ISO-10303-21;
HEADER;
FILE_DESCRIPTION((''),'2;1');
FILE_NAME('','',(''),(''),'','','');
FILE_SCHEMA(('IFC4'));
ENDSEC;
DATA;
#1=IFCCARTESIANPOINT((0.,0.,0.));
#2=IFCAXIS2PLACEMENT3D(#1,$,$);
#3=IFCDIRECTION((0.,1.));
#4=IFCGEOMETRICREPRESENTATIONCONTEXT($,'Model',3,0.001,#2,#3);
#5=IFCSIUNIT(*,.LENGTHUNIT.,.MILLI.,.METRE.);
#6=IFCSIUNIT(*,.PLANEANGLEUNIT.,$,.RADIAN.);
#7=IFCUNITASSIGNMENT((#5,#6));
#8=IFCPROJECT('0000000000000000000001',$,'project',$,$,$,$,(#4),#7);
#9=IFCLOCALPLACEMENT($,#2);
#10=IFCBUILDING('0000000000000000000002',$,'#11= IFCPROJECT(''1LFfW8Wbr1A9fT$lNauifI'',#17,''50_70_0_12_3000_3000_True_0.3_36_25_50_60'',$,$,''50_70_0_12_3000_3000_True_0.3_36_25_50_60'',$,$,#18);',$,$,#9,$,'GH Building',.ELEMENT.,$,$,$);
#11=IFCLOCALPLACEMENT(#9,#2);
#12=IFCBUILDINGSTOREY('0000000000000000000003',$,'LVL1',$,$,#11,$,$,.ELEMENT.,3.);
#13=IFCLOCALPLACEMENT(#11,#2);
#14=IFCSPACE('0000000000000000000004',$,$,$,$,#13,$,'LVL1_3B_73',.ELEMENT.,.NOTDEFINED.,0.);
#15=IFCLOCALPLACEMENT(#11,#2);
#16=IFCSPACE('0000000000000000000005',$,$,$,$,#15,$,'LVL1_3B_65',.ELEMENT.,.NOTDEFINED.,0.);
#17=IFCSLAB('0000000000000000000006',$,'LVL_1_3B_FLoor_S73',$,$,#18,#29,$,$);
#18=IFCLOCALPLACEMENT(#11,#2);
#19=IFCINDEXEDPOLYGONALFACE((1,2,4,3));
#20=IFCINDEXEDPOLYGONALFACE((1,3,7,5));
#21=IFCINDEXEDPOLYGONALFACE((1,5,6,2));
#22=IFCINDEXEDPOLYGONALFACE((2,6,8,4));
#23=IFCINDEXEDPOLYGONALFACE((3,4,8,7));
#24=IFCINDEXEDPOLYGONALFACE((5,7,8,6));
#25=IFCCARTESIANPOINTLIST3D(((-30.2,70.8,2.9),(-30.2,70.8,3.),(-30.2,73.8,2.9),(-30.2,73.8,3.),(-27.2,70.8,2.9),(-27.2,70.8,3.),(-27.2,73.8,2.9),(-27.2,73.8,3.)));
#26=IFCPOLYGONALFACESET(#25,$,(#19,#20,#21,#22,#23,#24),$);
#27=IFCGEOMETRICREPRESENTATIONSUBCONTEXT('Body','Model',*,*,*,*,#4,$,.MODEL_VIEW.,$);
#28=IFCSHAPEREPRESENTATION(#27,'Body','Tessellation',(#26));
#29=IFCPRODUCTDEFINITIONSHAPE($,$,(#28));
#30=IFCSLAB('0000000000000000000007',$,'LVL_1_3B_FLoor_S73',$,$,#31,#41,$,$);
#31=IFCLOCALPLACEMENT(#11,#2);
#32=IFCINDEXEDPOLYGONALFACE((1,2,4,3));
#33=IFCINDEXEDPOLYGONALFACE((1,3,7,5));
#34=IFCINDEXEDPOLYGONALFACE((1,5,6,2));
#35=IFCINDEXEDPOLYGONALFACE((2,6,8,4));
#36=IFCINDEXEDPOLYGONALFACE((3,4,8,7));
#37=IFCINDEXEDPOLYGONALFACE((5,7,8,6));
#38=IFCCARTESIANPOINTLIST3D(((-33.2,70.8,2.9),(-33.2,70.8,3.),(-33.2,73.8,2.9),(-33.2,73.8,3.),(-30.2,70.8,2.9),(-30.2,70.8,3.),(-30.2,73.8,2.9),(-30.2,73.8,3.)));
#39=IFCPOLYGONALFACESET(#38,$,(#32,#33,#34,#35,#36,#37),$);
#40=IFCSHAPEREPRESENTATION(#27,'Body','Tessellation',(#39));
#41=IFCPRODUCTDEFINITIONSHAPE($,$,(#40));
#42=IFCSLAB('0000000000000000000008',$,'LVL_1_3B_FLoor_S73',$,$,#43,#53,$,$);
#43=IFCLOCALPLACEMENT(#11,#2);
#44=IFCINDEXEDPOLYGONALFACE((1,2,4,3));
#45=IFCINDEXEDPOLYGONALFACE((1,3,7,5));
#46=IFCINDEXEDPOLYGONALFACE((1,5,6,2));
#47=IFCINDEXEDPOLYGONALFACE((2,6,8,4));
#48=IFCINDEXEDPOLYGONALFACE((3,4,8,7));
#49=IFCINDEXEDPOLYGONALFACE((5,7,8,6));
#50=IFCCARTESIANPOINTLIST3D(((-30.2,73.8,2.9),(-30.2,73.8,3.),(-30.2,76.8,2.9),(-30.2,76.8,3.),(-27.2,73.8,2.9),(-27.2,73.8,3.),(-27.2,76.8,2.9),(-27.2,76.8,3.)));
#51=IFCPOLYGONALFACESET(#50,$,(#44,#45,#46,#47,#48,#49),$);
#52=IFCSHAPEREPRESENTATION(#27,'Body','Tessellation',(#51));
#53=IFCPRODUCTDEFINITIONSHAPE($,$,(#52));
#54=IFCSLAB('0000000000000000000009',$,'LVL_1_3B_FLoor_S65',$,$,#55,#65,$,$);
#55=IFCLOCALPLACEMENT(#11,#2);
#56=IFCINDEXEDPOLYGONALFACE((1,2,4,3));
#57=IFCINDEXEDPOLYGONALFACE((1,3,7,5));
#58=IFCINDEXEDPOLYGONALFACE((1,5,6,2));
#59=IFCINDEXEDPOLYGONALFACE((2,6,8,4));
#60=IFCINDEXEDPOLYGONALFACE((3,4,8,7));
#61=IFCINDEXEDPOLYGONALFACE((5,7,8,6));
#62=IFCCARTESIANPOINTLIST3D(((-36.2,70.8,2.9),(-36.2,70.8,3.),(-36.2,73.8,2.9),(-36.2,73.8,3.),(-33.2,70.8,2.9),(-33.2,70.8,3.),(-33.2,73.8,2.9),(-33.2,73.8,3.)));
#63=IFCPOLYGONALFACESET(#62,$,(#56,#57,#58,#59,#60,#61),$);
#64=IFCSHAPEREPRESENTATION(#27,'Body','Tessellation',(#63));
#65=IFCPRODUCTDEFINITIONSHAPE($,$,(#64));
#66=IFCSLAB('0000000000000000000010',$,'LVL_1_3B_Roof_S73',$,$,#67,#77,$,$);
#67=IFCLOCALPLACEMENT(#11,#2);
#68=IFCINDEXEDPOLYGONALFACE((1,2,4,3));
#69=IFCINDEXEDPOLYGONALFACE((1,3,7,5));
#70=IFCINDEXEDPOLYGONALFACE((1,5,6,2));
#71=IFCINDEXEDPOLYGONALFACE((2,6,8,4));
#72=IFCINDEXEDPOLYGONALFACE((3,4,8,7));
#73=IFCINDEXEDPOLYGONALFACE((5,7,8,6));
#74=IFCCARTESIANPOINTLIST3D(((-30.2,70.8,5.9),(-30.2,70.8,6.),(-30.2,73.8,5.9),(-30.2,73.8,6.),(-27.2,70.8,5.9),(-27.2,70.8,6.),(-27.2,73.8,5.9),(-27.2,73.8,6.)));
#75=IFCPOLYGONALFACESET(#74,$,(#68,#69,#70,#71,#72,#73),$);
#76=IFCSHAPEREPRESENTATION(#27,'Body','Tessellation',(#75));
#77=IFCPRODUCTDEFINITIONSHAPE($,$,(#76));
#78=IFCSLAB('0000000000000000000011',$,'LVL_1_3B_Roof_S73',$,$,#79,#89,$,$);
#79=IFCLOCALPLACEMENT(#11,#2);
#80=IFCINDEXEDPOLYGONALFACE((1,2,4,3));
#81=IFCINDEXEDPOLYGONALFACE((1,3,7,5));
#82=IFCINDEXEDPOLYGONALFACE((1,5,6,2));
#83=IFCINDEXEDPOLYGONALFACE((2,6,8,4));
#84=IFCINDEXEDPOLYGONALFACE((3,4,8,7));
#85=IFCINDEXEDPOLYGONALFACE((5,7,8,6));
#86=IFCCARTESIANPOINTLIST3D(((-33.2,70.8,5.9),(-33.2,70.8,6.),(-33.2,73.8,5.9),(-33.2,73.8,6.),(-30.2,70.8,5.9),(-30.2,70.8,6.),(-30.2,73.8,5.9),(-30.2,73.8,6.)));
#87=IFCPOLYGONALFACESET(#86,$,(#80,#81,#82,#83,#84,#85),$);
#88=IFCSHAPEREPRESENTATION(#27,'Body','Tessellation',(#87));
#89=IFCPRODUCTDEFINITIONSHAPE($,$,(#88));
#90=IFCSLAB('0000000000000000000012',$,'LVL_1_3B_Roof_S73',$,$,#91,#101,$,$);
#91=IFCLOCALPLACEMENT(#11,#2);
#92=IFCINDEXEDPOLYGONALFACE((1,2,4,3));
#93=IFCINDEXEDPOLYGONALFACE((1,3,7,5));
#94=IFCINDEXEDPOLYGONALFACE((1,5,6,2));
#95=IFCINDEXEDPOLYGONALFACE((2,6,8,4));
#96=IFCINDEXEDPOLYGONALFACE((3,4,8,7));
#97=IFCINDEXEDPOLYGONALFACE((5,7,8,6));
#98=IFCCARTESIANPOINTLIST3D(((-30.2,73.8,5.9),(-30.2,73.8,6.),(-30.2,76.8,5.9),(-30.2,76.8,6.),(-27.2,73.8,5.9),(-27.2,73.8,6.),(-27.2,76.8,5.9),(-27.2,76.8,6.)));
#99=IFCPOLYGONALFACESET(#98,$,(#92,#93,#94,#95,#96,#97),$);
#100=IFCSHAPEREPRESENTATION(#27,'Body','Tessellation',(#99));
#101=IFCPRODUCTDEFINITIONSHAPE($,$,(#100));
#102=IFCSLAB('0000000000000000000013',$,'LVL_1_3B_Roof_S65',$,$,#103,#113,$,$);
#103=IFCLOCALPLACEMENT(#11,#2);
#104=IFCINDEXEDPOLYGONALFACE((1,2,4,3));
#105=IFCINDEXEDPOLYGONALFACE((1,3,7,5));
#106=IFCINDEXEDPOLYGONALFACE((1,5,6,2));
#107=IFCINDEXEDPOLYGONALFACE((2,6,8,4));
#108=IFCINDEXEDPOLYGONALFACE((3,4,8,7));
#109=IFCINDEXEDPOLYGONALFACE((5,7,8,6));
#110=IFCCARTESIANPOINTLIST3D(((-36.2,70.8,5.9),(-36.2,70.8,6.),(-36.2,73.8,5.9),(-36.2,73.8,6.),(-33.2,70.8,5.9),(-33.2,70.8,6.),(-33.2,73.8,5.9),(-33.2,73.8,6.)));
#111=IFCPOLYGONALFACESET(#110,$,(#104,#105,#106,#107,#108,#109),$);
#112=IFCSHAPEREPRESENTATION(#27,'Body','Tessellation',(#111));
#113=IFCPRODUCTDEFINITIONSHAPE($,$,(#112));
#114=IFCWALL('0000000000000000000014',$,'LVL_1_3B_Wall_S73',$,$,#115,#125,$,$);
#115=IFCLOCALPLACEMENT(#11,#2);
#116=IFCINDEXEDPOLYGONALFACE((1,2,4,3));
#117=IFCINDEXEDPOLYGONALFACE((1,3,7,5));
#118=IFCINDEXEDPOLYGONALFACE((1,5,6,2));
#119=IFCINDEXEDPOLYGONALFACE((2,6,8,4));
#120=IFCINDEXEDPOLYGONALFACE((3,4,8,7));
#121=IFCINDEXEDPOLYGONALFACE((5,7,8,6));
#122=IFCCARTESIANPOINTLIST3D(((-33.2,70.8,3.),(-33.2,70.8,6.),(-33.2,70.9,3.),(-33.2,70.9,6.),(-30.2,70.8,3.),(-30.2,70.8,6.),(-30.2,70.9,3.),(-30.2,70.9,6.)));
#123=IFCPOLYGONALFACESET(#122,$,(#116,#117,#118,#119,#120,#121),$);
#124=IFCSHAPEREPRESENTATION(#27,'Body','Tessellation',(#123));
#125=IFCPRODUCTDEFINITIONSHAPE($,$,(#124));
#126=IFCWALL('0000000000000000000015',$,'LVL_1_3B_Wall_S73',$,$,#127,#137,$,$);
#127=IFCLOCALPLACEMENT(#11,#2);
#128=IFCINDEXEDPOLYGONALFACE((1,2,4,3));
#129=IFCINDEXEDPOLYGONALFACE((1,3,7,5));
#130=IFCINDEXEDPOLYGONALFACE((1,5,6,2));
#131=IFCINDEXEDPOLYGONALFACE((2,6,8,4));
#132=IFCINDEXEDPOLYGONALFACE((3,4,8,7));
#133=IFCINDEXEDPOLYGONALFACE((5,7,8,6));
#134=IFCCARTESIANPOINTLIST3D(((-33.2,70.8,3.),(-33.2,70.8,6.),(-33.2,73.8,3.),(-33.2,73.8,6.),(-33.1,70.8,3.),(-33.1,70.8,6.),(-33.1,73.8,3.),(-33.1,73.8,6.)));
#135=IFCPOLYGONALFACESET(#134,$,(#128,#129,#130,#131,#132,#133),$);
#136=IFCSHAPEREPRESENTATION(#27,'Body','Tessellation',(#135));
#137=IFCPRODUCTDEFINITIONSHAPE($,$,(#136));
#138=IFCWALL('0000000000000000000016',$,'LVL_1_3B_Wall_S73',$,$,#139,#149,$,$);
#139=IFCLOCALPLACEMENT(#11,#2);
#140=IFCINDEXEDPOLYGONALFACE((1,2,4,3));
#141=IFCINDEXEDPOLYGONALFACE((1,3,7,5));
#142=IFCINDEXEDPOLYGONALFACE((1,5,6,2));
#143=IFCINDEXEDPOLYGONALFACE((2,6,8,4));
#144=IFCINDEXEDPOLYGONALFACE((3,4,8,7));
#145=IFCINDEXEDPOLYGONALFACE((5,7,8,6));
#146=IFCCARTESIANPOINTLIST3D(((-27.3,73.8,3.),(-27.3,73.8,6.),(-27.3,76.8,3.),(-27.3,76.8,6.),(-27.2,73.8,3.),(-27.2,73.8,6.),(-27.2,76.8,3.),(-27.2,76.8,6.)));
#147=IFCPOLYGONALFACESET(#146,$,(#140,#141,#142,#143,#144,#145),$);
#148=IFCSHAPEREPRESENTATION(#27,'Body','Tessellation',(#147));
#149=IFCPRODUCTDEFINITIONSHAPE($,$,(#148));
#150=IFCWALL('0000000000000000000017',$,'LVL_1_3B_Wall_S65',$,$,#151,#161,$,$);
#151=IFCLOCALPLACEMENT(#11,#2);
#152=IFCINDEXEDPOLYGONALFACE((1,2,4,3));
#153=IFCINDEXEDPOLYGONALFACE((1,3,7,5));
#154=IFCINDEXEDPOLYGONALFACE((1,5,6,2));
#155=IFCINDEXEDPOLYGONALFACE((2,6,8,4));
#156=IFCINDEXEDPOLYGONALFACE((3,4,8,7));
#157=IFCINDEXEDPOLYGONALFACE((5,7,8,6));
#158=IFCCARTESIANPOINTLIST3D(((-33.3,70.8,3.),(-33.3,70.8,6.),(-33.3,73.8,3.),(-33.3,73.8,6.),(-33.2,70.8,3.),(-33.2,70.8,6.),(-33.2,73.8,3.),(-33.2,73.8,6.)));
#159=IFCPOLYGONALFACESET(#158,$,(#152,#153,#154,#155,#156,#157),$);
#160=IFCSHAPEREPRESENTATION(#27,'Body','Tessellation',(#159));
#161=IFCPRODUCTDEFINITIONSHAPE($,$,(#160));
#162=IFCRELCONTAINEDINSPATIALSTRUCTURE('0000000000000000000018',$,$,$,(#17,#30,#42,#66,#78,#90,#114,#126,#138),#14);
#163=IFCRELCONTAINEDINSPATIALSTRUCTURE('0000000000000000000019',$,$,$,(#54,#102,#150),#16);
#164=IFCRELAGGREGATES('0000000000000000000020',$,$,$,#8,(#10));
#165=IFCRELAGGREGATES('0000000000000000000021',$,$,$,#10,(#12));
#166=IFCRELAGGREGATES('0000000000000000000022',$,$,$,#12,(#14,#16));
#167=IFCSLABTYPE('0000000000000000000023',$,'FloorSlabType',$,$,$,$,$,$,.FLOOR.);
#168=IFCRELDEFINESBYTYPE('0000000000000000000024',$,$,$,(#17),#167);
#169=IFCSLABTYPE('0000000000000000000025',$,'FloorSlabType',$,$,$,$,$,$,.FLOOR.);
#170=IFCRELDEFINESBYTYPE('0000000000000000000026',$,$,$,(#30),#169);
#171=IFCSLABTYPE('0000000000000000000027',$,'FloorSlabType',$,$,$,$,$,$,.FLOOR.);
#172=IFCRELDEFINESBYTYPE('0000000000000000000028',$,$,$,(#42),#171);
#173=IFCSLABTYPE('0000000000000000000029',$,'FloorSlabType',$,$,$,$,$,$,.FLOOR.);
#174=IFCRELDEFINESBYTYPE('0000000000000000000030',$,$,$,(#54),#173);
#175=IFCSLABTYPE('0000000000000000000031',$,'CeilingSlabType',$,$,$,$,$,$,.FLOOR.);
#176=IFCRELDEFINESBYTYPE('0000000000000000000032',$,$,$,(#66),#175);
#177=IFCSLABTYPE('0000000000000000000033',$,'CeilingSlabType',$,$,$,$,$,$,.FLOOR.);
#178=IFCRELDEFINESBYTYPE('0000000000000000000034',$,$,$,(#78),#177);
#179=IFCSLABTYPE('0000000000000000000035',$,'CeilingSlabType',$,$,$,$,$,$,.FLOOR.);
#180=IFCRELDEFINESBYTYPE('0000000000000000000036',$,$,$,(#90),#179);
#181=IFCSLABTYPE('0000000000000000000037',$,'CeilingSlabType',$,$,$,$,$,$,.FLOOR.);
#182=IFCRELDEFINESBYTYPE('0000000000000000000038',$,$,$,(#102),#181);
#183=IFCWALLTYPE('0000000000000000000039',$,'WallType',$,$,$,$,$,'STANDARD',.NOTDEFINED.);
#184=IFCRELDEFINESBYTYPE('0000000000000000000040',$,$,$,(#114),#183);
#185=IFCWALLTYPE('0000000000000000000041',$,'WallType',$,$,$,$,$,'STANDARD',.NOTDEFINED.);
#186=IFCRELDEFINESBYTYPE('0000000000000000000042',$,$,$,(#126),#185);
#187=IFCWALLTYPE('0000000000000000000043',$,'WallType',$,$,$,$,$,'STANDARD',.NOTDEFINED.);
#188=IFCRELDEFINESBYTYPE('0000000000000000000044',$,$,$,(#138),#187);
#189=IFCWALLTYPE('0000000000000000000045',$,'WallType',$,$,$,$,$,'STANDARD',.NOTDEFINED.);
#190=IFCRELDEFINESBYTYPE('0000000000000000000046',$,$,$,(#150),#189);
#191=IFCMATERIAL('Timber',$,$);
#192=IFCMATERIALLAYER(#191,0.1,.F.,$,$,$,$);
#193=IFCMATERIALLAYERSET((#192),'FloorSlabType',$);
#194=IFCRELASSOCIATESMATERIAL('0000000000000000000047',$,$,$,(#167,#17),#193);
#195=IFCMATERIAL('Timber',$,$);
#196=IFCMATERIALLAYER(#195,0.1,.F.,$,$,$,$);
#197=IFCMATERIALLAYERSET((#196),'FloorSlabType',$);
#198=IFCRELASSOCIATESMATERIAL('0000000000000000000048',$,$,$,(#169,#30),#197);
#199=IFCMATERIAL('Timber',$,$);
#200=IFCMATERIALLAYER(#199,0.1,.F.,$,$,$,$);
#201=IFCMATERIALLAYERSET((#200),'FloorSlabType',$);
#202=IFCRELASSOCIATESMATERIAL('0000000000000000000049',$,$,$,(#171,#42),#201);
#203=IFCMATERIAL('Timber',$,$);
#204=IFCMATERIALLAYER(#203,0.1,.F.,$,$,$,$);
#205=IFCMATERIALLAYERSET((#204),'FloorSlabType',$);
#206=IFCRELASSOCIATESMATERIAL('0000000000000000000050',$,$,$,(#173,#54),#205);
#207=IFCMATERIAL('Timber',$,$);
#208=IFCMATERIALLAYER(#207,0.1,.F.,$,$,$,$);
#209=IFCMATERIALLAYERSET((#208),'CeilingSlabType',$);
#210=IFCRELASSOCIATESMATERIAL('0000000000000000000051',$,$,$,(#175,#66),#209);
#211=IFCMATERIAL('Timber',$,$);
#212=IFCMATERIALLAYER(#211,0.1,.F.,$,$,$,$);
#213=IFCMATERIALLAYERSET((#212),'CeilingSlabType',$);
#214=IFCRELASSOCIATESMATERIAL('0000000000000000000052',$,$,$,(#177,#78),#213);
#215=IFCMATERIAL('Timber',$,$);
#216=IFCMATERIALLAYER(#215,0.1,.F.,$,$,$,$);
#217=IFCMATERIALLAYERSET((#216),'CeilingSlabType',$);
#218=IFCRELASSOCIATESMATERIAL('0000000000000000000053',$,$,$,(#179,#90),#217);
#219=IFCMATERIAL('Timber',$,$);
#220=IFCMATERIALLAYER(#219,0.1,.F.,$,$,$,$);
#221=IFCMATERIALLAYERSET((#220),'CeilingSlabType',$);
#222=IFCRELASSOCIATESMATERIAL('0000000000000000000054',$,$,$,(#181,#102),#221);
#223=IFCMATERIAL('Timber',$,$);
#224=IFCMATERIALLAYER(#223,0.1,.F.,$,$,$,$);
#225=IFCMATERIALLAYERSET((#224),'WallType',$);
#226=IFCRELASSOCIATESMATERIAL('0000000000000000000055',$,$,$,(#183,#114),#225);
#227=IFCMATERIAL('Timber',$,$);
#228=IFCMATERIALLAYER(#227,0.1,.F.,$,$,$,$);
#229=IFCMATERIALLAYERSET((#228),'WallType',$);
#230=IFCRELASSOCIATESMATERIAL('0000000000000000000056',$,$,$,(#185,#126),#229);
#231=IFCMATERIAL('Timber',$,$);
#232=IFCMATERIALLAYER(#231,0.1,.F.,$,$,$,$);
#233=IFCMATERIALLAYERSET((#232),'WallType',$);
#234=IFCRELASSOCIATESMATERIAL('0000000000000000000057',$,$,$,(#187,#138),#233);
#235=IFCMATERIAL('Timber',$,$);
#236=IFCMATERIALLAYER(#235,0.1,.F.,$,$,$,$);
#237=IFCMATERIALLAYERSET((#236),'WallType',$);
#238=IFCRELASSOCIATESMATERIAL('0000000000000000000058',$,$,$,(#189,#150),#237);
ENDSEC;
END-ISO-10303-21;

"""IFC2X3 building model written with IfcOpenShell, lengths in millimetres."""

from ifc_helpers import new_model, si_unit, direction, frame, frame_2d, origin, place, context, subcontext, project, spatial, rectangle, extrude, material, layer, layer_set, layer_usage, type_object, element, save


model = new_model("IFC2X3")

# Units and contexts
model_context = context("Model", 3, precision=0.001, world=origin(), true_north=direction((0.0, 1.0)))
body_context = subcontext(model_context, "Body", "Model", "MODEL_VIEW")
ifc_project = project(units=[si_unit("LENGTHUNIT", "METRE", prefix="MILLI"), si_unit("PLANEANGLEUNIT", "RADIAN")], contexts=[model_context])

# Building, storey
building_placement = place(None, origin())
building = spatial("IfcBuilding", under=ifc_project, at=building_placement, Name="#11= IFCPROJECT('1LFfW8Wbr1A9fT$lNauifI',#17,'50_70_0_12_3000_3000_True_0.3_36_25_50_60',$,$,'50_70_0_12_3000_3000_True_0.3_36_25_50_60',$,$,#18);", LongName="GH Building", CompositionType="ELEMENT")
storey_placement = place(building_placement, origin())
storey = spatial("IfcBuildingStorey", under=building, at=storey_placement, Name="LVL1", CompositionType="ELEMENT", Elevation=3.0)

# Shared definitions
space_1_placement = place(storey_placement, origin())
space_1 = spatial("IfcSpace", under=storey, at=space_1_placement, LongName="LVL1_3B_73", CompositionType="ELEMENT", InteriorOrExteriorSpace="NOTDEFINED", ElevationWithFlooring=0.0)

# Slabs
ifc_material_1 = material(Name="Timber")
ifc_layer_1 = layer(ifc_material_1, 0.1, ventilated=False)
ifc_layer_set_1 = layer_set([ifc_layer_1], Name="FloorSlabType")
ifc_layer_usage_1 = layer_usage(ifc_layer_set_1, "AXIS3", "NEGATIVE", -0.1)
slab_type_1 = type_object("IfcSlabType", Name="FloorSlabType", PredefinedType="FLOOR", material=ifc_layer_set_1)
slab_1_placement = place(space_1_placement, frame((-27.2, 73.8, 2.9), z_axis=(0.0, 0.0, 1.0), x_axis=(-1.0, 0.0, 0.0)))
element("IfcSlab", 1, at=slab_1_placement, inside=space_1, type_object=slab_type_1, material=ifc_layer_usage_1, Name="LVL_1_3B_FLoor_S73", context=body_context, shape_type="SweptSolid", body=[
    extrude(rectangle(XDim=3.0, YDim=3.0, at=frame_2d((1.5, 1.5))), origin(), (0.0, 0.0, 1.0), 0.1),
])
ifc_material_2 = material(Name="Timber")
ifc_layer_2 = layer(ifc_material_2, 0.1, ventilated=False)
ifc_layer_set_2 = layer_set([ifc_layer_2], Name="FloorSlabType")
ifc_layer_usage_2 = layer_usage(ifc_layer_set_2, "AXIS3", "NEGATIVE", -0.1)
slab_type_2 = type_object("IfcSlabType", Name="FloorSlabType", PredefinedType="FLOOR", material=ifc_layer_set_2)
slab_2_placement = place(space_1_placement, frame((-30.2, 73.8, 2.9), z_axis=(0.0, 0.0, 1.0), x_axis=(-1.0, 0.0, 0.0)))
element("IfcSlab", 2, at=slab_2_placement, inside=space_1, type_object=slab_type_2, material=ifc_layer_usage_2, Name="LVL_1_3B_FLoor_S73", context=body_context, shape_type="SweptSolid", body=[
    extrude(rectangle(XDim=3.0, YDim=3.0, at=frame_2d((1.5, 1.5))), origin(), (0.0, 0.0, 1.0), 0.1),
])
ifc_material_3 = material(Name="Timber")
ifc_layer_3 = layer(ifc_material_3, 0.1, ventilated=False)
ifc_layer_set_3 = layer_set([ifc_layer_3], Name="FloorSlabType")
ifc_layer_usage_3 = layer_usage(ifc_layer_set_3, "AXIS3", "NEGATIVE", -0.1)
slab_type_3 = type_object("IfcSlabType", Name="FloorSlabType", PredefinedType="FLOOR", material=ifc_layer_set_3)
slab_3_placement = place(space_1_placement, frame((-27.2, 76.8, 2.9), z_axis=(0.0, 0.0, 1.0), x_axis=(-1.0, 0.0, 0.0)))
element("IfcSlab", 3, at=slab_3_placement, inside=space_1, type_object=slab_type_3, material=ifc_layer_usage_3, Name="LVL_1_3B_FLoor_S73", context=body_context, shape_type="SweptSolid", body=[
    extrude(rectangle(XDim=3.0, YDim=3.0, at=frame_2d((1.5, 1.5))), origin(), (0.0, 0.0, 1.0), 0.1),
])

# Shared definitions
space_2_placement = place(storey_placement, origin())
space_2 = spatial("IfcSpace", under=storey, at=space_2_placement, LongName="LVL1_3B_65", CompositionType="ELEMENT", InteriorOrExteriorSpace="NOTDEFINED", ElevationWithFlooring=0.0)

# Slabs
ifc_material_4 = material(Name="Timber")
ifc_layer_4 = layer(ifc_material_4, 0.1, ventilated=False)
ifc_layer_set_4 = layer_set([ifc_layer_4], Name="FloorSlabType")
ifc_layer_usage_4 = layer_usage(ifc_layer_set_4, "AXIS3", "NEGATIVE", -0.1)
slab_type_4 = type_object("IfcSlabType", Name="FloorSlabType", PredefinedType="FLOOR", material=ifc_layer_set_4)
slab_4_placement = place(space_2_placement, frame((-33.2, 73.8, 2.9), z_axis=(0.0, 0.0, 1.0), x_axis=(-1.0, 0.0, 0.0)))
element("IfcSlab", 4, at=slab_4_placement, inside=space_2, type_object=slab_type_4, material=ifc_layer_usage_4, Name="LVL_1_3B_FLoor_S65", context=body_context, shape_type="SweptSolid", body=[
    extrude(rectangle(XDim=3.0, YDim=3.0, at=frame_2d((1.5, 1.5))), origin(), (0.0, 0.0, 1.0), 0.1),
])
ifc_material_5 = material(Name="Timber")
ifc_layer_5 = layer(ifc_material_5, 0.1, ventilated=False)
ifc_layer_set_5 = layer_set([ifc_layer_5], Name="CeilingSlabType")
ifc_layer_usage_5 = layer_usage(ifc_layer_set_5, "AXIS3", "NEGATIVE", -0.1)
slab_type_5 = type_object("IfcSlabType", Name="CeilingSlabType", PredefinedType="FLOOR", material=ifc_layer_set_5)
slab_5_placement = place(space_1_placement, frame((-27.2, 73.8, 5.9), z_axis=(0.0, 0.0, 1.0), x_axis=(-1.0, 0.0, 0.0)))
element("IfcSlab", 5, at=slab_5_placement, inside=space_1, type_object=slab_type_5, material=ifc_layer_usage_5, Name="LVL_1_3B_Roof_S73", context=body_context, shape_type="SweptSolid", body=[
    extrude(rectangle(XDim=3.0, YDim=3.0, at=frame_2d((1.5, 1.5))), origin(), (0.0, 0.0, 1.0), 0.1),
])
ifc_material_6 = material(Name="Timber")
ifc_layer_6 = layer(ifc_material_6, 0.1, ventilated=False)
ifc_layer_set_6 = layer_set([ifc_layer_6], Name="CeilingSlabType")
ifc_layer_usage_6 = layer_usage(ifc_layer_set_6, "AXIS3", "NEGATIVE", -0.1)
slab_type_6 = type_object("IfcSlabType", Name="CeilingSlabType", PredefinedType="FLOOR", material=ifc_layer_set_6)
slab_6_placement = place(space_1_placement, frame((-30.2, 73.8, 5.9), z_axis=(0.0, 0.0, 1.0), x_axis=(-1.0, 0.0, 0.0)))
element("IfcSlab", 6, at=slab_6_placement, inside=space_1, type_object=slab_type_6, material=ifc_layer_usage_6, Name="LVL_1_3B_Roof_S73", context=body_context, shape_type="SweptSolid", body=[
    extrude(rectangle(XDim=3.0, YDim=3.0, at=frame_2d((1.5, 1.5))), origin(), (0.0, 0.0, 1.0), 0.1),
])
ifc_material_7 = material(Name="Timber")
ifc_layer_7 = layer(ifc_material_7, 0.1, ventilated=False)
ifc_layer_set_7 = layer_set([ifc_layer_7], Name="CeilingSlabType")
ifc_layer_usage_7 = layer_usage(ifc_layer_set_7, "AXIS3", "NEGATIVE", -0.1)
slab_type_7 = type_object("IfcSlabType", Name="CeilingSlabType", PredefinedType="FLOOR", material=ifc_layer_set_7)
slab_7_placement = place(space_1_placement, frame((-27.2, 76.8, 5.9), z_axis=(0.0, 0.0, 1.0), x_axis=(-1.0, 0.0, 0.0)))
element("IfcSlab", 7, at=slab_7_placement, inside=space_1, type_object=slab_type_7, material=ifc_layer_usage_7, Name="LVL_1_3B_Roof_S73", context=body_context, shape_type="SweptSolid", body=[
    extrude(rectangle(XDim=3.0, YDim=3.0, at=frame_2d((1.5, 1.5))), origin(), (0.0, 0.0, 1.0), 0.1),
])
ifc_material_8 = material(Name="Timber")
ifc_layer_8 = layer(ifc_material_8, 0.1, ventilated=False)
ifc_layer_set_8 = layer_set([ifc_layer_8], Name="CeilingSlabType")
ifc_layer_usage_8 = layer_usage(ifc_layer_set_8, "AXIS3", "NEGATIVE", -0.1)
slab_type_8 = type_object("IfcSlabType", Name="CeilingSlabType", PredefinedType="FLOOR", material=ifc_layer_set_8)
slab_8_placement = place(space_2_placement, frame((-33.2, 73.8, 5.9), z_axis=(0.0, 0.0, 1.0), x_axis=(-1.0, 0.0, 0.0)))
element("IfcSlab", 8, at=slab_8_placement, inside=space_2, type_object=slab_type_8, material=ifc_layer_usage_8, Name="LVL_1_3B_Roof_S65", context=body_context, shape_type="SweptSolid", body=[
    extrude(rectangle(XDim=3.0, YDim=3.0, at=frame_2d((1.5, 1.5))), origin(), (0.0, 0.0, 1.0), 0.1),
])

# Walls
ifc_material_9 = material(Name="Timber")
ifc_layer_9 = layer(ifc_material_9, 0.1, ventilated=False)
ifc_layer_set_9 = layer_set([ifc_layer_9], Name="WallType")
ifc_layer_usage_9 = layer_usage(ifc_layer_set_9, "AXIS2", "NEGATIVE", 0.0)
wall_type_1 = type_object("IfcWallType", Name="WallType", ElementType="STANDARD", PredefinedType="NOTDEFINED", material=ifc_layer_set_9)
wall_1_placement = place(space_1_placement, frame((-30.2, 70.8, 3.0), z_axis=(0.0, 0.0, 1.0), x_axis=(-1.0, 0.0, 0.0)))
element("IfcWall", 9, at=wall_1_placement, inside=space_1, type_object=wall_type_1, material=ifc_layer_usage_9, Name="LVL_1_3B_Wall_S73", context=body_context, shape_type="SweptSolid", body=[
    extrude(rectangle(XDim=3.0, YDim=0.1, at=frame_2d((1.5, -0.1))), origin(), (0.0, 0.0, 1.0), 3.0),
])
ifc_material_10 = material(Name="Timber")
ifc_layer_10 = layer(ifc_material_10, 0.1, ventilated=False)
ifc_layer_set_10 = layer_set([ifc_layer_10], Name="WallType")
ifc_layer_usage_10 = layer_usage(ifc_layer_set_10, "AXIS2", "NEGATIVE", 0.0)
wall_type_2 = type_object("IfcWallType", Name="WallType", ElementType="STANDARD", PredefinedType="NOTDEFINED", material=ifc_layer_set_10)
wall_2_placement = place(space_1_placement, frame((-33.2, 70.8, 3.0), z_axis=(0.0, 0.0, 1.0), x_axis=(0.0, 1.0, 0.0)))
element("IfcWall", 10, at=wall_2_placement, inside=space_1, type_object=wall_type_2, material=ifc_layer_usage_10, Name="LVL_1_3B_Wall_S73", context=body_context, shape_type="SweptSolid", body=[
    extrude(rectangle(XDim=3.0, YDim=0.1, at=frame_2d((1.5, -0.1))), origin(), (0.0, 0.0, 1.0), 3.0),
])
ifc_material_11 = material(Name="Timber")
ifc_layer_11 = layer(ifc_material_11, 0.1, ventilated=False)
ifc_layer_set_11 = layer_set([ifc_layer_11], Name="WallType")
ifc_layer_usage_11 = layer_usage(ifc_layer_set_11, "AXIS2", "NEGATIVE", 0.0)
wall_type_3 = type_object("IfcWallType", Name="WallType", ElementType="STANDARD", PredefinedType="NOTDEFINED", material=ifc_layer_set_11)
wall_3_placement = place(space_1_placement, frame((-27.2, 76.8, 3.0), z_axis=(0.0, 0.0, 1.0), x_axis=(0.0, -1.0, 0.0)))
element("IfcWall", 11, at=wall_3_placement, inside=space_1, type_object=wall_type_3, material=ifc_layer_usage_11, Name="LVL_1_3B_Wall_S73", context=body_context, shape_type="SweptSolid", body=[
    extrude(rectangle(XDim=3.0, YDim=0.1, at=frame_2d((1.5, -0.1))), origin(), (0.0, 0.0, 1.0), 3.0),
])
ifc_material_12 = material(Name="Timber")
ifc_layer_12 = layer(ifc_material_12, 0.1, ventilated=False)
ifc_layer_set_12 = layer_set([ifc_layer_12], Name="WallType")
ifc_layer_usage_12 = layer_usage(ifc_layer_set_12, "AXIS2", "NEGATIVE", 0.0)
wall_type_4 = type_object("IfcWallType", Name="WallType", ElementType="STANDARD", PredefinedType="NOTDEFINED", material=ifc_layer_set_12)
wall_4_placement = place(space_2_placement, frame((-33.2, 73.8, 3.0), z_axis=(0.0, 0.0, 1.0), x_axis=(0.0, -1.0, 0.0)))
element("IfcWall", 12, at=wall_4_placement, inside=space_2, type_object=wall_type_4, material=ifc_layer_usage_12, Name="LVL_1_3B_Wall_S65", context=body_context, shape_type="SweptSolid", body=[
    extrude(rectangle(XDim=3.0, YDim=0.1, at=frame_2d((1.5, -0.1))), origin(), (0.0, 0.0, 1.0), 3.0),
])

save(model, "model.ifc")
